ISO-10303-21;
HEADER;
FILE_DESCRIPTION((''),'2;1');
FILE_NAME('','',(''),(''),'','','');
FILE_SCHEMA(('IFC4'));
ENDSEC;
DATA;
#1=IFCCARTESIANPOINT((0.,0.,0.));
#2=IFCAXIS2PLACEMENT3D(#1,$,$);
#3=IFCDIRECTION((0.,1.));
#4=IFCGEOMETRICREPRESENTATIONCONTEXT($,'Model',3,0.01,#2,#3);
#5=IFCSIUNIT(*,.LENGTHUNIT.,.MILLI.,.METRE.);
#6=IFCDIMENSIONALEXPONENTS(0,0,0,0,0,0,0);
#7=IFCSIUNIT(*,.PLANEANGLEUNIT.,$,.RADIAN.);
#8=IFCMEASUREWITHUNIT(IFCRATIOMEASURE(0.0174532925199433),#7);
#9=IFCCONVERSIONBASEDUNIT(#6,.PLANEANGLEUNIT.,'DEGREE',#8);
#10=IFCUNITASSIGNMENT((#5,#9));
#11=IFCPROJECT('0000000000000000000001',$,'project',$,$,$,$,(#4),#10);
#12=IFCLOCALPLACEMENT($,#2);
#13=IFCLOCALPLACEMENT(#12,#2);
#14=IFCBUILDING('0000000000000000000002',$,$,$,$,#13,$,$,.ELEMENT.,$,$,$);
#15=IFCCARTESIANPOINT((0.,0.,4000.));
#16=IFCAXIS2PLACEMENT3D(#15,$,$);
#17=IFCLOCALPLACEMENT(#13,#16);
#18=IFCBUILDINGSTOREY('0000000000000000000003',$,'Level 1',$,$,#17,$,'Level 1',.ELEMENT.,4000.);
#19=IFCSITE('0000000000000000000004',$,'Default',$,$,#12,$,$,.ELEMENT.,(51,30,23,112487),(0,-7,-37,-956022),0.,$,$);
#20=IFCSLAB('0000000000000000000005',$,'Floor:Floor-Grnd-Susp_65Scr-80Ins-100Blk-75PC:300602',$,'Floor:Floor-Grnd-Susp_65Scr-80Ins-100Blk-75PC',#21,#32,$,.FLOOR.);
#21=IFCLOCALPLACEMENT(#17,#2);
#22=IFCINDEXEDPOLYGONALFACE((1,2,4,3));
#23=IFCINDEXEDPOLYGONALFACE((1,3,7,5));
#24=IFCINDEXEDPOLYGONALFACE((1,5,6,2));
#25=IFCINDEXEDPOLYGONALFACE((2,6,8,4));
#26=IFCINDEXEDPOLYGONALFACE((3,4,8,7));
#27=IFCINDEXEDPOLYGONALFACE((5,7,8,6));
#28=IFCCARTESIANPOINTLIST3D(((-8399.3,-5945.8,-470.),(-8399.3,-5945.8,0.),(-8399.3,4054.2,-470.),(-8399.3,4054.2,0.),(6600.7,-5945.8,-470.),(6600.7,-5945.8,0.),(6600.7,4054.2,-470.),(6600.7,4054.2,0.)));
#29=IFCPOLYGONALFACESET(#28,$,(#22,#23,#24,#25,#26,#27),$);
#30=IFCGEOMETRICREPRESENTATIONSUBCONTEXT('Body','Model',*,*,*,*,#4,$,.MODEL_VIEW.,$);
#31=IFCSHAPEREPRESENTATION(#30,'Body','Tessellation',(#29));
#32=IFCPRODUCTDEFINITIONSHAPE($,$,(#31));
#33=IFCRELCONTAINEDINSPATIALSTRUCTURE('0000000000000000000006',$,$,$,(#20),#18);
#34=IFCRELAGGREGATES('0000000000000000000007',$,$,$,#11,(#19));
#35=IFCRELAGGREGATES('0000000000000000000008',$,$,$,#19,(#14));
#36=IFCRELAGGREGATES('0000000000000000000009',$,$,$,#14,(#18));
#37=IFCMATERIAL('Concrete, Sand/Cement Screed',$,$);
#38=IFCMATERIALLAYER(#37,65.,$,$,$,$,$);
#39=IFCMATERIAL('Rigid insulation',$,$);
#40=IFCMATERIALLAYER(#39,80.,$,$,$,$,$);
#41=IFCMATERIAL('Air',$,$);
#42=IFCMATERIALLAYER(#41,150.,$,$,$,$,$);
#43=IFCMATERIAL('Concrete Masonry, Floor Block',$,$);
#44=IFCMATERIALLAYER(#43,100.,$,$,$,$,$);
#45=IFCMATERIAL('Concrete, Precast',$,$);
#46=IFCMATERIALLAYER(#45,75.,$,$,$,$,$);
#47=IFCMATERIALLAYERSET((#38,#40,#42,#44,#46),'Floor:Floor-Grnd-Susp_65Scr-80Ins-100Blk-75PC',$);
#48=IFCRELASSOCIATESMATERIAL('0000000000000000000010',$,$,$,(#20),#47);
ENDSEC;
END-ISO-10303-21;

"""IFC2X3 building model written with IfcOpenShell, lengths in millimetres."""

from ifc_helpers import new_model, entity, si_unit, converted_unit, direction, frame, origin, origin_2d_with_axis, place, context, subcontext, project, spatial, rectangle, extrude, material, layer, layer_set, layer_usage, element, save


model = new_model("IFC2X3")

# Units and contexts
model_context = context("Model", 3, precision=0.01, world=origin(), true_north=direction((0.0, 1.0)))
body_context = subcontext(model_context, "Body", "Model", "MODEL_VIEW")
ifc_project = project(units=[si_unit("LENGTHUNIT", "METRE", prefix="MILLI"), converted_unit("PLANEANGLEUNIT", "DEGREE", entity("IfcRatioMeasure", 0.0174532925199433), si_unit("PLANEANGLEUNIT", "RADIAN"), dimensions=[0, 0, 0, 0, 0, 0, 0])], contexts=[model_context])

# Site, building, storey
site_placement = place(None, origin())
site = spatial("IfcSite", under=ifc_project, at=site_placement, Name="Default", CompositionType="ELEMENT", RefLatitude=(51, 30, 23, 112487), RefLongitude=(0, -7, -37, -956022), RefElevation=0.0)
building_placement = place(site_placement, origin())
building = spatial("IfcBuilding", under=site, at=building_placement, CompositionType="ELEMENT")
storey_placement = place(building_placement, frame((0.0, 0.0, 4000.0)))
storey = spatial("IfcBuildingStorey", under=building, at=storey_placement, Name="Level 1", LongName="Level 1", CompositionType="ELEMENT", Elevation=4000.0)

# Slab
ifc_material_1 = material(Name="Concrete, Sand/Cement Screed")
ifc_layer_1 = layer(ifc_material_1, 65.0)
ifc_material_2 = material(Name="Rigid insulation")
ifc_layer_2 = layer(ifc_material_2, 80.0)
ifc_material_3 = material(Name="Air")
ifc_layer_3 = layer(ifc_material_3, 150.0)
ifc_material_4 = material(Name="Concrete Masonry, Floor Block")
ifc_layer_4 = layer(ifc_material_4, 100.0)
ifc_material_5 = material(Name="Concrete, Precast")
ifc_layer_5 = layer(ifc_material_5, 75.0)
ifc_layer_set = layer_set([ifc_layer_1, ifc_layer_2, ifc_layer_3, ifc_layer_4, ifc_layer_5], Name="Floor:Floor-Grnd-Susp_65Scr-80Ins-100Blk-75PC")
ifc_layer_usage = layer_usage(ifc_layer_set, "AXIS3", "POSITIVE", 0.0)
slab_placement = place(storey_placement, origin())
element("IfcSlab", 1, at=slab_placement, inside=storey, material=ifc_layer_usage, Name="Floor:Floor-Grnd-Susp_65Scr-80Ins-100Blk-75PC:300602", ObjectType="Floor:Floor-Grnd-Susp_65Scr-80Ins-100Blk-75PC", PredefinedType="FLOOR", context=body_context, shape_type="SweptSolid", body=[
    extrude(rectangle(XDim=10000.0, YDim=15000.0, at=origin_2d_with_axis()), frame((-899.3, -945.8, 0.0), z_axis=(0.0, 0.0, -1.0), x_axis=(0.0, 1.0, 0.0)), (0.0, 0.0, 1.0), 470.0),
])

save(model, "model.ifc")
